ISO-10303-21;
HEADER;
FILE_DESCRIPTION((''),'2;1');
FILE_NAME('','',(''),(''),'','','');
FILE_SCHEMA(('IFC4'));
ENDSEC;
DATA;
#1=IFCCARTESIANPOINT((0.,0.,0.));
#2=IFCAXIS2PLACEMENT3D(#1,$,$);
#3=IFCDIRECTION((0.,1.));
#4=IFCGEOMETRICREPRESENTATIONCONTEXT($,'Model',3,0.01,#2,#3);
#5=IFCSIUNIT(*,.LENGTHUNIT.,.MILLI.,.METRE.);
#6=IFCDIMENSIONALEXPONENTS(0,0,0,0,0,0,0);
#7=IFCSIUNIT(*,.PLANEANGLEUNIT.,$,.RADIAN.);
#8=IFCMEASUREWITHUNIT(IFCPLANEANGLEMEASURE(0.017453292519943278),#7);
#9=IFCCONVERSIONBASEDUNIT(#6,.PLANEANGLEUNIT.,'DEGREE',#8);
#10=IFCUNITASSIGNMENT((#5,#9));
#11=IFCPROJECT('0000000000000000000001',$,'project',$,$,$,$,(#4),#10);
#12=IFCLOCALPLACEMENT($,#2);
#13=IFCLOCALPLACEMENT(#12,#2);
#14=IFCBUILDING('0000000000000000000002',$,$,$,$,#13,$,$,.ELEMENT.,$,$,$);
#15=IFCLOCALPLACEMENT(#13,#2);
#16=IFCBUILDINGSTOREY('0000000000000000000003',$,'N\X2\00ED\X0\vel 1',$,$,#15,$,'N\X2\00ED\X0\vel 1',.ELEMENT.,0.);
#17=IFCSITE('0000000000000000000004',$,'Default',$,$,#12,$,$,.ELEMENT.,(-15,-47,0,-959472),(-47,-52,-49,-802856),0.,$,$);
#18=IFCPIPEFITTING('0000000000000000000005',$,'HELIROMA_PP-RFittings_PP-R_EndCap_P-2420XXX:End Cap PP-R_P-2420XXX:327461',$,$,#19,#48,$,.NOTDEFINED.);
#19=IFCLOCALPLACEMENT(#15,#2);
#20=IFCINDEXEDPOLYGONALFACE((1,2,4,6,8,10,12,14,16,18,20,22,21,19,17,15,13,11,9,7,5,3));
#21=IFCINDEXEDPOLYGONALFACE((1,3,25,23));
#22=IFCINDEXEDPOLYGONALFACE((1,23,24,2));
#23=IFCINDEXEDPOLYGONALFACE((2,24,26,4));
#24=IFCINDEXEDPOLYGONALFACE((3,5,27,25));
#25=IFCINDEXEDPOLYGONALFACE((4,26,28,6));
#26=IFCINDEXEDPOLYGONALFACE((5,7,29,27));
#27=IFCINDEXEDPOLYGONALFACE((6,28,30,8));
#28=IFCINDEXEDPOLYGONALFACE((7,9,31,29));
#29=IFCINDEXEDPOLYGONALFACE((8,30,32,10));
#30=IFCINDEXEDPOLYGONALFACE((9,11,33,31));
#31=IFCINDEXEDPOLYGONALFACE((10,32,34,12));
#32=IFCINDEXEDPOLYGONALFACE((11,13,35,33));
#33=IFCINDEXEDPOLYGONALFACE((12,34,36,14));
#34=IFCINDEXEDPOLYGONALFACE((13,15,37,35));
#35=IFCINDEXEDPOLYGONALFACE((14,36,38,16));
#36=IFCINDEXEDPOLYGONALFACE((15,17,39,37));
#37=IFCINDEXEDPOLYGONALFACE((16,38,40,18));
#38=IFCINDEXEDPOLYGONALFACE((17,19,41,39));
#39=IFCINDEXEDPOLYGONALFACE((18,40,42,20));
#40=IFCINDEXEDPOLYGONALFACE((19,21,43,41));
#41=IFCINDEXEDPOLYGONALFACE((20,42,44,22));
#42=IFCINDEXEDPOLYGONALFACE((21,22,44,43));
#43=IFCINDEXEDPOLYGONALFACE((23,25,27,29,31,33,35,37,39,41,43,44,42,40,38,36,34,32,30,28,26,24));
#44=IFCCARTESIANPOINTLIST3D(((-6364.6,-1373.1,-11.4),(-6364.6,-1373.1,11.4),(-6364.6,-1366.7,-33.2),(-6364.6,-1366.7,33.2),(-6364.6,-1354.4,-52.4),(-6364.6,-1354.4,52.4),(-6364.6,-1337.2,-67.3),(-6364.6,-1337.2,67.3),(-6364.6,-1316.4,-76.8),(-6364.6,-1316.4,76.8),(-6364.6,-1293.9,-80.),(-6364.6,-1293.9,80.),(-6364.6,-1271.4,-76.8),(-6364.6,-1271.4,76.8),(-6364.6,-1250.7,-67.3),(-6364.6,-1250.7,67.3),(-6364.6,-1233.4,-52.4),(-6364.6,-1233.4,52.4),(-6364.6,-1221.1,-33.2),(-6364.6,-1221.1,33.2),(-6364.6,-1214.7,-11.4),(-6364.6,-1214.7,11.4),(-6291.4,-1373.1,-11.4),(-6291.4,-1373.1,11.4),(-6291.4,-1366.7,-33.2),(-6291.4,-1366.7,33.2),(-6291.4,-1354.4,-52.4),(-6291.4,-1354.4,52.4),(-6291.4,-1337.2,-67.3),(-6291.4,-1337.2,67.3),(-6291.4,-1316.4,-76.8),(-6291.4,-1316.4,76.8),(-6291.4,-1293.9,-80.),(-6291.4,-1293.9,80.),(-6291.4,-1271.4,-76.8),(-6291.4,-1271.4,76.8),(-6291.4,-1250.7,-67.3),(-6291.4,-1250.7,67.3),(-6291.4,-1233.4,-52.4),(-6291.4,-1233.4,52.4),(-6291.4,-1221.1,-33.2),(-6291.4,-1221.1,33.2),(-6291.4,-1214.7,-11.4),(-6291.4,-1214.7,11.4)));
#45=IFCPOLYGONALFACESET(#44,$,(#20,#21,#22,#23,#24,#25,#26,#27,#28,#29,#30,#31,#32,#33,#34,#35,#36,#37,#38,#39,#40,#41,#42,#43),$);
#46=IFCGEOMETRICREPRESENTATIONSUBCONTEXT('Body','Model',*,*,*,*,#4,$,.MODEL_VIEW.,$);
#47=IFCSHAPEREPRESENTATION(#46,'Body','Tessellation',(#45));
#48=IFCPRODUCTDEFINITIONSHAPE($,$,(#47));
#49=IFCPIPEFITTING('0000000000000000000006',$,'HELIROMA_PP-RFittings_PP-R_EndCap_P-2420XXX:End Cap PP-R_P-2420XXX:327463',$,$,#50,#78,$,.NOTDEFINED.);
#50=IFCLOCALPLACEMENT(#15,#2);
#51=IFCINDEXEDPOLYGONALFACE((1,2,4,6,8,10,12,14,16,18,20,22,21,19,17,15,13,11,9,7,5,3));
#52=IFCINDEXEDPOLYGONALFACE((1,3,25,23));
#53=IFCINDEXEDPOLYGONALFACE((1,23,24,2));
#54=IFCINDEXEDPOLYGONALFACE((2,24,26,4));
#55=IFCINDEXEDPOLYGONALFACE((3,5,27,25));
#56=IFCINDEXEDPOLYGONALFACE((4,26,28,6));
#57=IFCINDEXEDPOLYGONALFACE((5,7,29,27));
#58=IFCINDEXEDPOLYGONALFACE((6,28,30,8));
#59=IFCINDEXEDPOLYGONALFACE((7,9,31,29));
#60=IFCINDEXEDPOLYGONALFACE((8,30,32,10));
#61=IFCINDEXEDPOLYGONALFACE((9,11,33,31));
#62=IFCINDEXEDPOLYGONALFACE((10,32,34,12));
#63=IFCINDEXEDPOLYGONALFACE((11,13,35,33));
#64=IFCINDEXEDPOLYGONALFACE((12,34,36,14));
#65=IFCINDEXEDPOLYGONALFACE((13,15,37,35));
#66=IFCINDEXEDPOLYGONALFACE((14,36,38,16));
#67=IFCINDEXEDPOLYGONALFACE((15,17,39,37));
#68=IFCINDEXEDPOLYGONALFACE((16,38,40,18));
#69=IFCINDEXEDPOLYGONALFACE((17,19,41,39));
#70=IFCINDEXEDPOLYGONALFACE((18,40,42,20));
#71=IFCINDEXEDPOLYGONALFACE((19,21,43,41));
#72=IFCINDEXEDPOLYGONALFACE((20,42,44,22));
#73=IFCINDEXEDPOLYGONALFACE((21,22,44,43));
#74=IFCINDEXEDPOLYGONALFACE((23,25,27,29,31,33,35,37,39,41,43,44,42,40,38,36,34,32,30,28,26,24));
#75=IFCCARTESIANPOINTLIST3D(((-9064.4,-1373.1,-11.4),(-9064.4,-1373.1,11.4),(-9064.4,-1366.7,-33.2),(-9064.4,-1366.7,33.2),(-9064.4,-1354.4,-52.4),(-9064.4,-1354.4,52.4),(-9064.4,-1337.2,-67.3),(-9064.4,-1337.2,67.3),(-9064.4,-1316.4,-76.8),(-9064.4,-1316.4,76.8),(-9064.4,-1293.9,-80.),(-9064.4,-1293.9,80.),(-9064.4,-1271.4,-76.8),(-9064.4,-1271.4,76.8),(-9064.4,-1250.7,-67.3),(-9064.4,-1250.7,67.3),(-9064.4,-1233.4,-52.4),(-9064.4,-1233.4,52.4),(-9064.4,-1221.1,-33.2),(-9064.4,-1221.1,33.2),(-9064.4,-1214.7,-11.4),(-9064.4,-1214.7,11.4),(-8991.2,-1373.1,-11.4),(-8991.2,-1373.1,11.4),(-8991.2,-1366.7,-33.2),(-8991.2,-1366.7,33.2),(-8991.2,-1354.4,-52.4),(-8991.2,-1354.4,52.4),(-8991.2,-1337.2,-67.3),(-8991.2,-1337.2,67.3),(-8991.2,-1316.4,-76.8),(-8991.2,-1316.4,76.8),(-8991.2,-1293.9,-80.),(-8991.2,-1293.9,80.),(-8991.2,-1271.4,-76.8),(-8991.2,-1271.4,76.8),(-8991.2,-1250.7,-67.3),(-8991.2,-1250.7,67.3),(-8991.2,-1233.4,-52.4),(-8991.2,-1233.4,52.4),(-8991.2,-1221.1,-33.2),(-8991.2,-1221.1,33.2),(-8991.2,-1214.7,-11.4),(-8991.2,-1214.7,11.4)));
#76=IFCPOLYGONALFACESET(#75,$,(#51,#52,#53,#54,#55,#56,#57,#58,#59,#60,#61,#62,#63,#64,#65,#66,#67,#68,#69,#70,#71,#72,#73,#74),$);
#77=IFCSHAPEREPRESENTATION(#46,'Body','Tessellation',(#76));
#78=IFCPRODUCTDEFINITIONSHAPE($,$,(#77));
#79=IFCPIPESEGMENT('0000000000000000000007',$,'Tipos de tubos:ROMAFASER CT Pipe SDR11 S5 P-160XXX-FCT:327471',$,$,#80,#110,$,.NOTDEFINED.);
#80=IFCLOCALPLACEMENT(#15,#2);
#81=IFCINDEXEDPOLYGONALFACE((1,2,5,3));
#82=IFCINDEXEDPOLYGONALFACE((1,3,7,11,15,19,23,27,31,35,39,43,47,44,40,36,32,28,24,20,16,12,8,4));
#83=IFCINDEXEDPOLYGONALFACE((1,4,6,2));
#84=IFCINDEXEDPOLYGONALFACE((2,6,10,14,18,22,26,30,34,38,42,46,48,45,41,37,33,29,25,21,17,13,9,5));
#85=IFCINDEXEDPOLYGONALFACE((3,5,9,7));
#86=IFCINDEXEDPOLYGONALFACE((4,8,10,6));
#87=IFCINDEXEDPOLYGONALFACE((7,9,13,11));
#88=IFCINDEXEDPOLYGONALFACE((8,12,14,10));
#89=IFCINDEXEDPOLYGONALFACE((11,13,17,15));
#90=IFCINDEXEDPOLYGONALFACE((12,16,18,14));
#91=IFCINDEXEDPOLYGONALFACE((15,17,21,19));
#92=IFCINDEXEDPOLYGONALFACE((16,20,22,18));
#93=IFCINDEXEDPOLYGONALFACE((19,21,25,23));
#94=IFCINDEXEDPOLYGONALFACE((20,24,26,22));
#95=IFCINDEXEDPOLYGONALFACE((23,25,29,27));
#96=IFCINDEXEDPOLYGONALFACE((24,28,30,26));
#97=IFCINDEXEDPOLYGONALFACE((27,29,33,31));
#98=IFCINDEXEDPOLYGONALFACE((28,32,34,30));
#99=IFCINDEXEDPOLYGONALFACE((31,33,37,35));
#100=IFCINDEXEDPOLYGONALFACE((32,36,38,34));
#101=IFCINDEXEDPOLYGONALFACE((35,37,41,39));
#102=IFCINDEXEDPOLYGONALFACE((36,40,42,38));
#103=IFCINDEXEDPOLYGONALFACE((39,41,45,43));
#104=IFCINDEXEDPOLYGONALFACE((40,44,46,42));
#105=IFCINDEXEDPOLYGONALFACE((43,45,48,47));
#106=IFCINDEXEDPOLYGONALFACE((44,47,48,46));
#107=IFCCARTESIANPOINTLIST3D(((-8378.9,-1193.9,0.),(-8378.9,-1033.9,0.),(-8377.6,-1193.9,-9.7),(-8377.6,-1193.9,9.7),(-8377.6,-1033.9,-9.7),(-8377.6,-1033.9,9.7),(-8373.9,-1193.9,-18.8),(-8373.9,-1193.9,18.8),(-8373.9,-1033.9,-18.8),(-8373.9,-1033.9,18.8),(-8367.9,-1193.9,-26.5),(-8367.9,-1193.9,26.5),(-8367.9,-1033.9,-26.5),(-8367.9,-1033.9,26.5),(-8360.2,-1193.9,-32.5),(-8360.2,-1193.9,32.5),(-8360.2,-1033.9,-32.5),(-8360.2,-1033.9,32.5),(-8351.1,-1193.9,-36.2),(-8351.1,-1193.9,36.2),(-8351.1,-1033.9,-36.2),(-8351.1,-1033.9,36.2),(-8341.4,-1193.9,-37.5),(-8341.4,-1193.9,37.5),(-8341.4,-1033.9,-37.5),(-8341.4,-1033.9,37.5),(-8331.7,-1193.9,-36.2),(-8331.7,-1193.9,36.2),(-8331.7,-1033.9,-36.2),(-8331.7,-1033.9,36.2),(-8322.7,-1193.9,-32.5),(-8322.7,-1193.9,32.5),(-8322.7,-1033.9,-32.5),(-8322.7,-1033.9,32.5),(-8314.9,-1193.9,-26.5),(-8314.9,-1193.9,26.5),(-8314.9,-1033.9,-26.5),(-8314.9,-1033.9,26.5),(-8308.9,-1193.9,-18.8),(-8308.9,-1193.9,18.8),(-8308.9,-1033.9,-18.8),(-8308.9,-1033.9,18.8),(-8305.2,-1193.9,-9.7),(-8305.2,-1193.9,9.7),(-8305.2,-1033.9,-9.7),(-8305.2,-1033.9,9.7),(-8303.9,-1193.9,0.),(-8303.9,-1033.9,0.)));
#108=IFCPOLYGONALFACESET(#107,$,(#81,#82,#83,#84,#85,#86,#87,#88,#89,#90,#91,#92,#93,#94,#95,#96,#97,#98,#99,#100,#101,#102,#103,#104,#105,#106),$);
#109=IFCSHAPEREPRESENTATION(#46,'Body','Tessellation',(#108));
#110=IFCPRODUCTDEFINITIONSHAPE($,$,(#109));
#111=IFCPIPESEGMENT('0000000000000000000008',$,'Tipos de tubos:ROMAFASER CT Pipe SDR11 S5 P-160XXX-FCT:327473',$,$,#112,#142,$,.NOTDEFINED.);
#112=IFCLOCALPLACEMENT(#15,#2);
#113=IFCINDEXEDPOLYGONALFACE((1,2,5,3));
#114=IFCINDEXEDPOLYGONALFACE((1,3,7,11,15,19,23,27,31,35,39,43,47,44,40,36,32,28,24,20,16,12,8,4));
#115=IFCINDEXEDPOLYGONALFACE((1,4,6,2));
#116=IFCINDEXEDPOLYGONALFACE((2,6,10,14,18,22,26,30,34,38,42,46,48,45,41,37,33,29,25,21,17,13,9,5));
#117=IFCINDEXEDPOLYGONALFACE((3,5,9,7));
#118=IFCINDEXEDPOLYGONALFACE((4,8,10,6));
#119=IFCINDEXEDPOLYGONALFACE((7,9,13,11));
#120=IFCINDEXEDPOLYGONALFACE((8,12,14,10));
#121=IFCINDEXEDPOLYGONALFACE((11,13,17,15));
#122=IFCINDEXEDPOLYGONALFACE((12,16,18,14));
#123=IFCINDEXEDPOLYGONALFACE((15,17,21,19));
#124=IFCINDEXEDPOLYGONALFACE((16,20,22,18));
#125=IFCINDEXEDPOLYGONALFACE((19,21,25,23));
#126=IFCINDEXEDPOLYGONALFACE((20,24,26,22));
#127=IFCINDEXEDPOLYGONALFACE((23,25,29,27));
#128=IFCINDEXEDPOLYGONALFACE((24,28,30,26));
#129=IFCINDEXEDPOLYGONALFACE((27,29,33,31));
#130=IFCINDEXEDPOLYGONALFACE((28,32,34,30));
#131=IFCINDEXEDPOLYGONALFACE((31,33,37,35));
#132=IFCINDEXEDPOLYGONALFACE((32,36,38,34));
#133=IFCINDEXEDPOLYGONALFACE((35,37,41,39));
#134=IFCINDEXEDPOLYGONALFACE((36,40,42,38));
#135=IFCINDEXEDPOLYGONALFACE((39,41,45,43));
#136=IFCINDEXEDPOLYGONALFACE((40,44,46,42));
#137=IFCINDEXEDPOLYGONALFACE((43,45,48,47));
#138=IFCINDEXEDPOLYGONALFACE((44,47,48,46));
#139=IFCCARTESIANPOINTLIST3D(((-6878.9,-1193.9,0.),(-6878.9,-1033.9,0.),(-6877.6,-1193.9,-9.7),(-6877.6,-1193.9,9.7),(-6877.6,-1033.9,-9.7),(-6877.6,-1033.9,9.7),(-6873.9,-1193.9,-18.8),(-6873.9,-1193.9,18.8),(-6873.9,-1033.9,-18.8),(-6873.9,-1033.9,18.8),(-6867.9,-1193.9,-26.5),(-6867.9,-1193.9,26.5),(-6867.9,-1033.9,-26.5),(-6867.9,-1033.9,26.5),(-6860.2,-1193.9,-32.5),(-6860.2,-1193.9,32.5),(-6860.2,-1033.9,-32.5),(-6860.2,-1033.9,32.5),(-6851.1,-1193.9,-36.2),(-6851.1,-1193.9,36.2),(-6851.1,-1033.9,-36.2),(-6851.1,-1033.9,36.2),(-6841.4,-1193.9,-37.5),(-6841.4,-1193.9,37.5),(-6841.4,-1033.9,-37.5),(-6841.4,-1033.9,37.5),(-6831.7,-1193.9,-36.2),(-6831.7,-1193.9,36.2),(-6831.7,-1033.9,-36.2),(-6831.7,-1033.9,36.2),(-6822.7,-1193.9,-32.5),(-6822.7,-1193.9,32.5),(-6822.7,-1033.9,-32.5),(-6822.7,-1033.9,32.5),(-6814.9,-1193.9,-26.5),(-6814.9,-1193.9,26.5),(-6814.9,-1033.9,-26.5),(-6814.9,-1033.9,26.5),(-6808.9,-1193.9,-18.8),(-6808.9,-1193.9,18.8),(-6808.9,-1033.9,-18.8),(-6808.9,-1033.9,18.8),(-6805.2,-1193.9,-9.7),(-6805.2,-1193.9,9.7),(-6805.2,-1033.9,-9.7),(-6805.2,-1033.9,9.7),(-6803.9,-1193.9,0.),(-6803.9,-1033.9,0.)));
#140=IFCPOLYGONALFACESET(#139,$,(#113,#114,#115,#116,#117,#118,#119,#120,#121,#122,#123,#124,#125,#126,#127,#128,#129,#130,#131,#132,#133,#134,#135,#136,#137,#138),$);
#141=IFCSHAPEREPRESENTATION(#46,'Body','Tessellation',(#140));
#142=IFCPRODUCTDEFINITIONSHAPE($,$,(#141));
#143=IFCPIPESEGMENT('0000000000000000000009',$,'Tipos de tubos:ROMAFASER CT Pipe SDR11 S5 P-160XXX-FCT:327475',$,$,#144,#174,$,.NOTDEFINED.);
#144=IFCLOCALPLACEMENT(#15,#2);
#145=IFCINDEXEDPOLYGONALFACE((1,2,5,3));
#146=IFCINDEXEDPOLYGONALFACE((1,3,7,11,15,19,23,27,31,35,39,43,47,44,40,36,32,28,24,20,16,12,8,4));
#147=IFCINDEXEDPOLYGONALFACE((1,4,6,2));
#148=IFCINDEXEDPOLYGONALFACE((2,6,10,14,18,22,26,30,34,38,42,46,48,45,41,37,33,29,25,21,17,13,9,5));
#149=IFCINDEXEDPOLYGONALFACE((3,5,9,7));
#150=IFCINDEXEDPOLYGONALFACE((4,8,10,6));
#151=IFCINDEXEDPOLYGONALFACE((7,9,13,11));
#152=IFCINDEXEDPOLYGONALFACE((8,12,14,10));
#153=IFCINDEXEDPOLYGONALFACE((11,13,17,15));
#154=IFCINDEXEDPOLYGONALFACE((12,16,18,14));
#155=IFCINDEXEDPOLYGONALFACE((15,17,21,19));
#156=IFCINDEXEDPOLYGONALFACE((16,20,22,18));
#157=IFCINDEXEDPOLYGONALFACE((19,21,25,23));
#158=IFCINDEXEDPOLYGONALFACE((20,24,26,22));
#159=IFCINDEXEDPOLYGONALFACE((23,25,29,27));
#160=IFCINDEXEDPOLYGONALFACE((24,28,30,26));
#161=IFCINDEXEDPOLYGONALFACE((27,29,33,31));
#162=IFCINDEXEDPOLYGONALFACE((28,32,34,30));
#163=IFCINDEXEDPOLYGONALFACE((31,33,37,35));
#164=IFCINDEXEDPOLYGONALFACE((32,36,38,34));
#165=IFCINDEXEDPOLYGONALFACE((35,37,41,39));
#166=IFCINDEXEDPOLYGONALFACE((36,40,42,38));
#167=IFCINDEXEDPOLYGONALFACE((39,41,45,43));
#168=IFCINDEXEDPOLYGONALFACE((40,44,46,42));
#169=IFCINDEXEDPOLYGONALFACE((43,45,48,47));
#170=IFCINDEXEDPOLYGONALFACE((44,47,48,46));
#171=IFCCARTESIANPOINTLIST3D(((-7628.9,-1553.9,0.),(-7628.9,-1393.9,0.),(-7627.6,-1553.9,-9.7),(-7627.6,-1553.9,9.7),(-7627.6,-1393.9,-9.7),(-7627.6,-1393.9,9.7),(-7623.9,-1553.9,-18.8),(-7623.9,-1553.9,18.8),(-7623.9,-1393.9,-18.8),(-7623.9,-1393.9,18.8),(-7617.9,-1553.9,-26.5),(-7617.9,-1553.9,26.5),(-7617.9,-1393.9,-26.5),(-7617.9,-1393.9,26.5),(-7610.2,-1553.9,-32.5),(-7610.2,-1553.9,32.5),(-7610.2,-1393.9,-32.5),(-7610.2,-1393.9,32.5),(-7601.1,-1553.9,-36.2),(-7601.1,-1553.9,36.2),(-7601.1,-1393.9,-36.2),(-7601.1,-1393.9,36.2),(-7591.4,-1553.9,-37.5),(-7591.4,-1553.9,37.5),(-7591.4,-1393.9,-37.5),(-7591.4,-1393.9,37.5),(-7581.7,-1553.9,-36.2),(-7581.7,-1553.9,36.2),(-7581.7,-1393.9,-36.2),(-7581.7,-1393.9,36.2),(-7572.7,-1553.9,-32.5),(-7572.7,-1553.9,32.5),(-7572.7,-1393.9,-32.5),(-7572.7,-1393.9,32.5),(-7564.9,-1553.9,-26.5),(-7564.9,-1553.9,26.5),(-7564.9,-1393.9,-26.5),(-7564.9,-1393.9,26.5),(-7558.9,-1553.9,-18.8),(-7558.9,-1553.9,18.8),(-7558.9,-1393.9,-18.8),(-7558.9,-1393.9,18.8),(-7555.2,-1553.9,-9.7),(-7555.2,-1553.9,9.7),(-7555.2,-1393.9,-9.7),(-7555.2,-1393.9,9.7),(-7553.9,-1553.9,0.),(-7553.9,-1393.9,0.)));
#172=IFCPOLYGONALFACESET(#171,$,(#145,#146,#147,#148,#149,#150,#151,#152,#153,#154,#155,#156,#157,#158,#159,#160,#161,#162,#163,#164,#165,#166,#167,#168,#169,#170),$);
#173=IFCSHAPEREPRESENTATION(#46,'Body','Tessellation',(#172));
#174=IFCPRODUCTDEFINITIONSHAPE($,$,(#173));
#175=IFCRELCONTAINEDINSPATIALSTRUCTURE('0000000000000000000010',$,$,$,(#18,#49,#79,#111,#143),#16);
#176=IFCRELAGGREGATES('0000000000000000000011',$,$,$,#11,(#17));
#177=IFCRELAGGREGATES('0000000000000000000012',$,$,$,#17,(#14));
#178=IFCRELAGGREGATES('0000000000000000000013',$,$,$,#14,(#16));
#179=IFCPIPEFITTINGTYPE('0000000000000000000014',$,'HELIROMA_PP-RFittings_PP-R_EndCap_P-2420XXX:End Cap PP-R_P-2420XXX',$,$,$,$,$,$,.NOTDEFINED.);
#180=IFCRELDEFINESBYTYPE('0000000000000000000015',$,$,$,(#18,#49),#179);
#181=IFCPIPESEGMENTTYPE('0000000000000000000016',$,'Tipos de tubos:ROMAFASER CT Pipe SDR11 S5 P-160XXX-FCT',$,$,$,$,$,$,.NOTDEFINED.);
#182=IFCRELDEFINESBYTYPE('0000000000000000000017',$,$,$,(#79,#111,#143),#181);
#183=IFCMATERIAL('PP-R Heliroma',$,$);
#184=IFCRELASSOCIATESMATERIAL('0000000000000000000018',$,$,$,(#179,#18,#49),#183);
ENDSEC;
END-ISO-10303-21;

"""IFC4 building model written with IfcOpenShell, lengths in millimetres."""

from ifc_helpers import new_model, entity, si_unit, converted_unit, direction, frame, origin, place, context, subcontext, project, spatial, arc, indexed_curve, outline, extrude, source, transform, mapped, material, type_object, type_shapes, element, save


model = new_model("IFC4")

# Units and contexts
model_context = context("Model", 3, precision=0.01, world=origin(), true_north=direction((0.0, 1.0)))
body_context = subcontext(model_context, "Body", "Model", "MODEL_VIEW")
ifc_project = project(units=[si_unit("LENGTHUNIT", "METRE", prefix="MILLI"), converted_unit("PLANEANGLEUNIT", "DEGREE", entity("IfcPlaneAngleMeasure", 0.017453292519943278), si_unit("PLANEANGLEUNIT", "RADIAN"), dimensions=[0, 0, 0, 0, 0, 0, 0])], contexts=[model_context])

# Site, building, storey
site_placement = place(None, origin())
site = spatial("IfcSite", under=ifc_project, at=site_placement, Name="Default", CompositionType="ELEMENT", RefLatitude=(-15, -47, 0, -959472), RefLongitude=(-47, -52, -49, -802856), RefElevation=0.0)
building_placement = place(site_placement, origin())
building = spatial("IfcBuilding", under=site, at=building_placement, CompositionType="ELEMENT")
storey_placement = place(building_placement, origin())
storey = spatial("IfcBuildingStorey", under=building, at=storey_placement, Name="Nível 1", LongName="Nível 1", CompositionType="ELEMENT", Elevation=0.0)

# Pipe fittings
ifc_material = material(Name="PP-R Heliroma")
pipe_fitting_type = type_object("IfcPipeFittingType", Name="HELIROMA_PP-RFittings_PP-R_EndCap_P-2420XXX:End Cap PP-R_P-2420XXX", PredefinedType="NOTDEFINED", material=ifc_material)
shared_shape = source(origin(), body_context, "Body", "SweptSolid", [
    extrude(outline(indexed_curve([(-80.0, 0.0), (0.0, -80.0), (80.0, 0.0), (0.0, 80.0)], segments=[arc(1, 2, 3), arc(3, 4, 1)], self_intersect=False)), frame((0.0, 0.0, 0.0), z_axis=(1.0, 0.0, 0.0), x_axis=(0.0, 1.0, 0.0)), (0.0, 0.0, 1.0), 73.2),
])
type_shapes(pipe_fitting_type, [shared_shape])
for number, where, z_axis, x_axis, name in (
    (1, (-6364.6, -1293.9, 0.0), (0.0, -1.0, 0.0), (1.0, 0.0, 0.0), "HELIROMA_PP-RFittings_PP-R_EndCap_P-2420XXX:End Cap PP-R_P-2420XXX:327461"),
    (2, (-8991.2, -1293.9, 0.0), (0.0, 1.0, 0.0), (-1.0, 0.0, 0.0), "HELIROMA_PP-RFittings_PP-R_EndCap_P-2420XXX:End Cap PP-R_P-2420XXX:327463"),
):
    element("IfcPipeFitting", number, at=place(storey_placement, frame(where, z_axis=z_axis, x_axis=x_axis)), inside=storey, type_object=pipe_fitting_type, material=ifc_material, Name=name, PredefinedType="NOTDEFINED", context=body_context, shape_type="MappedRepresentation", body=[
        mapped(shared_shape, transform((0.0, 0.0, 0.0), scale=1.0)),
    ])

# Pipe segments
pipe_segment_type = type_object("IfcPipeSegmentType", Name="Tipos de tubos:ROMAFASER CT Pipe SDR11 S5 P-160XXX-FCT", PredefinedType="NOTDEFINED")
pipe_segment_1_placement = place(storey_placement, origin())
element("IfcPipeSegment", 3, at=pipe_segment_1_placement, inside=storey, type_object=pipe_segment_type, Name="Tipos de tubos:ROMAFASER CT Pipe SDR11 S5 P-160XXX-FCT:327471", PredefinedType="NOTDEFINED", context=body_context, shape_type="SweptSolid", body=[
    extrude(outline(indexed_curve([(37.5, 0.0), (26.5, 26.5), (0.0, 37.5), (-26.5, 26.5), (-37.5, 0.0), (-26.5, -26.5), (0.0, -37.5), (26.5, -26.5)], segments=[arc(1, 2, 3), arc(3, 4, 5), arc(5, 6, 7), arc(7, 8, 1)], self_intersect=False)), frame((-8341.4, -1193.9, 0.0), z_axis=(0.0, 1.0, 0.0), x_axis=(-1.0, 0.0, 0.0)), (0.0, 0.0, 1.0), 160.0),
])
pipe_segment_2_placement = place(storey_placement, origin())
element("IfcPipeSegment", 4, at=pipe_segment_2_placement, inside=storey, type_object=pipe_segment_type, Name="Tipos de tubos:ROMAFASER CT Pipe SDR11 S5 P-160XXX-FCT:327473", PredefinedType="NOTDEFINED", context=body_context, shape_type="SweptSolid", body=[
    extrude(outline(indexed_curve([(37.5, 0.0), (26.5, 26.5), (0.0, 37.5), (-26.5, 26.5), (-37.5, 0.0), (-26.5, -26.5), (0.0, -37.5), (26.5, -26.5)], segments=[arc(1, 2, 3), arc(3, 4, 5), arc(5, 6, 7), arc(7, 8, 1)], self_intersect=False)), frame((-6841.4, -1193.9, 0.0), z_axis=(0.0, 1.0, 0.0), x_axis=(-1.0, 0.0, 0.0)), (0.0, 0.0, 1.0), 160.0),
])
pipe_segment_3_placement = place(storey_placement, origin())
element("IfcPipeSegment", 5, at=pipe_segment_3_placement, inside=storey, type_object=pipe_segment_type, Name="Tipos de tubos:ROMAFASER CT Pipe SDR11 S5 P-160XXX-FCT:327475", PredefinedType="NOTDEFINED", context=body_context, shape_type="SweptSolid", body=[
    extrude(outline(indexed_curve([(37.5, 0.0), (26.5, 26.5), (0.0, 37.5), (-26.5, 26.5), (-37.5, 0.0), (-26.5, -26.5), (0.0, -37.5), (26.5, -26.5)], segments=[arc(1, 2, 3), arc(3, 4, 5), arc(5, 6, 7), arc(7, 8, 1)], self_intersect=False)), frame((-7591.4, -1553.9, 0.0), z_axis=(0.0, 1.0, 0.0), x_axis=(1.0, 0.0, 0.0)), (0.0, 0.0, 1.0), 160.0),
])

save(model, "model.ifc")
